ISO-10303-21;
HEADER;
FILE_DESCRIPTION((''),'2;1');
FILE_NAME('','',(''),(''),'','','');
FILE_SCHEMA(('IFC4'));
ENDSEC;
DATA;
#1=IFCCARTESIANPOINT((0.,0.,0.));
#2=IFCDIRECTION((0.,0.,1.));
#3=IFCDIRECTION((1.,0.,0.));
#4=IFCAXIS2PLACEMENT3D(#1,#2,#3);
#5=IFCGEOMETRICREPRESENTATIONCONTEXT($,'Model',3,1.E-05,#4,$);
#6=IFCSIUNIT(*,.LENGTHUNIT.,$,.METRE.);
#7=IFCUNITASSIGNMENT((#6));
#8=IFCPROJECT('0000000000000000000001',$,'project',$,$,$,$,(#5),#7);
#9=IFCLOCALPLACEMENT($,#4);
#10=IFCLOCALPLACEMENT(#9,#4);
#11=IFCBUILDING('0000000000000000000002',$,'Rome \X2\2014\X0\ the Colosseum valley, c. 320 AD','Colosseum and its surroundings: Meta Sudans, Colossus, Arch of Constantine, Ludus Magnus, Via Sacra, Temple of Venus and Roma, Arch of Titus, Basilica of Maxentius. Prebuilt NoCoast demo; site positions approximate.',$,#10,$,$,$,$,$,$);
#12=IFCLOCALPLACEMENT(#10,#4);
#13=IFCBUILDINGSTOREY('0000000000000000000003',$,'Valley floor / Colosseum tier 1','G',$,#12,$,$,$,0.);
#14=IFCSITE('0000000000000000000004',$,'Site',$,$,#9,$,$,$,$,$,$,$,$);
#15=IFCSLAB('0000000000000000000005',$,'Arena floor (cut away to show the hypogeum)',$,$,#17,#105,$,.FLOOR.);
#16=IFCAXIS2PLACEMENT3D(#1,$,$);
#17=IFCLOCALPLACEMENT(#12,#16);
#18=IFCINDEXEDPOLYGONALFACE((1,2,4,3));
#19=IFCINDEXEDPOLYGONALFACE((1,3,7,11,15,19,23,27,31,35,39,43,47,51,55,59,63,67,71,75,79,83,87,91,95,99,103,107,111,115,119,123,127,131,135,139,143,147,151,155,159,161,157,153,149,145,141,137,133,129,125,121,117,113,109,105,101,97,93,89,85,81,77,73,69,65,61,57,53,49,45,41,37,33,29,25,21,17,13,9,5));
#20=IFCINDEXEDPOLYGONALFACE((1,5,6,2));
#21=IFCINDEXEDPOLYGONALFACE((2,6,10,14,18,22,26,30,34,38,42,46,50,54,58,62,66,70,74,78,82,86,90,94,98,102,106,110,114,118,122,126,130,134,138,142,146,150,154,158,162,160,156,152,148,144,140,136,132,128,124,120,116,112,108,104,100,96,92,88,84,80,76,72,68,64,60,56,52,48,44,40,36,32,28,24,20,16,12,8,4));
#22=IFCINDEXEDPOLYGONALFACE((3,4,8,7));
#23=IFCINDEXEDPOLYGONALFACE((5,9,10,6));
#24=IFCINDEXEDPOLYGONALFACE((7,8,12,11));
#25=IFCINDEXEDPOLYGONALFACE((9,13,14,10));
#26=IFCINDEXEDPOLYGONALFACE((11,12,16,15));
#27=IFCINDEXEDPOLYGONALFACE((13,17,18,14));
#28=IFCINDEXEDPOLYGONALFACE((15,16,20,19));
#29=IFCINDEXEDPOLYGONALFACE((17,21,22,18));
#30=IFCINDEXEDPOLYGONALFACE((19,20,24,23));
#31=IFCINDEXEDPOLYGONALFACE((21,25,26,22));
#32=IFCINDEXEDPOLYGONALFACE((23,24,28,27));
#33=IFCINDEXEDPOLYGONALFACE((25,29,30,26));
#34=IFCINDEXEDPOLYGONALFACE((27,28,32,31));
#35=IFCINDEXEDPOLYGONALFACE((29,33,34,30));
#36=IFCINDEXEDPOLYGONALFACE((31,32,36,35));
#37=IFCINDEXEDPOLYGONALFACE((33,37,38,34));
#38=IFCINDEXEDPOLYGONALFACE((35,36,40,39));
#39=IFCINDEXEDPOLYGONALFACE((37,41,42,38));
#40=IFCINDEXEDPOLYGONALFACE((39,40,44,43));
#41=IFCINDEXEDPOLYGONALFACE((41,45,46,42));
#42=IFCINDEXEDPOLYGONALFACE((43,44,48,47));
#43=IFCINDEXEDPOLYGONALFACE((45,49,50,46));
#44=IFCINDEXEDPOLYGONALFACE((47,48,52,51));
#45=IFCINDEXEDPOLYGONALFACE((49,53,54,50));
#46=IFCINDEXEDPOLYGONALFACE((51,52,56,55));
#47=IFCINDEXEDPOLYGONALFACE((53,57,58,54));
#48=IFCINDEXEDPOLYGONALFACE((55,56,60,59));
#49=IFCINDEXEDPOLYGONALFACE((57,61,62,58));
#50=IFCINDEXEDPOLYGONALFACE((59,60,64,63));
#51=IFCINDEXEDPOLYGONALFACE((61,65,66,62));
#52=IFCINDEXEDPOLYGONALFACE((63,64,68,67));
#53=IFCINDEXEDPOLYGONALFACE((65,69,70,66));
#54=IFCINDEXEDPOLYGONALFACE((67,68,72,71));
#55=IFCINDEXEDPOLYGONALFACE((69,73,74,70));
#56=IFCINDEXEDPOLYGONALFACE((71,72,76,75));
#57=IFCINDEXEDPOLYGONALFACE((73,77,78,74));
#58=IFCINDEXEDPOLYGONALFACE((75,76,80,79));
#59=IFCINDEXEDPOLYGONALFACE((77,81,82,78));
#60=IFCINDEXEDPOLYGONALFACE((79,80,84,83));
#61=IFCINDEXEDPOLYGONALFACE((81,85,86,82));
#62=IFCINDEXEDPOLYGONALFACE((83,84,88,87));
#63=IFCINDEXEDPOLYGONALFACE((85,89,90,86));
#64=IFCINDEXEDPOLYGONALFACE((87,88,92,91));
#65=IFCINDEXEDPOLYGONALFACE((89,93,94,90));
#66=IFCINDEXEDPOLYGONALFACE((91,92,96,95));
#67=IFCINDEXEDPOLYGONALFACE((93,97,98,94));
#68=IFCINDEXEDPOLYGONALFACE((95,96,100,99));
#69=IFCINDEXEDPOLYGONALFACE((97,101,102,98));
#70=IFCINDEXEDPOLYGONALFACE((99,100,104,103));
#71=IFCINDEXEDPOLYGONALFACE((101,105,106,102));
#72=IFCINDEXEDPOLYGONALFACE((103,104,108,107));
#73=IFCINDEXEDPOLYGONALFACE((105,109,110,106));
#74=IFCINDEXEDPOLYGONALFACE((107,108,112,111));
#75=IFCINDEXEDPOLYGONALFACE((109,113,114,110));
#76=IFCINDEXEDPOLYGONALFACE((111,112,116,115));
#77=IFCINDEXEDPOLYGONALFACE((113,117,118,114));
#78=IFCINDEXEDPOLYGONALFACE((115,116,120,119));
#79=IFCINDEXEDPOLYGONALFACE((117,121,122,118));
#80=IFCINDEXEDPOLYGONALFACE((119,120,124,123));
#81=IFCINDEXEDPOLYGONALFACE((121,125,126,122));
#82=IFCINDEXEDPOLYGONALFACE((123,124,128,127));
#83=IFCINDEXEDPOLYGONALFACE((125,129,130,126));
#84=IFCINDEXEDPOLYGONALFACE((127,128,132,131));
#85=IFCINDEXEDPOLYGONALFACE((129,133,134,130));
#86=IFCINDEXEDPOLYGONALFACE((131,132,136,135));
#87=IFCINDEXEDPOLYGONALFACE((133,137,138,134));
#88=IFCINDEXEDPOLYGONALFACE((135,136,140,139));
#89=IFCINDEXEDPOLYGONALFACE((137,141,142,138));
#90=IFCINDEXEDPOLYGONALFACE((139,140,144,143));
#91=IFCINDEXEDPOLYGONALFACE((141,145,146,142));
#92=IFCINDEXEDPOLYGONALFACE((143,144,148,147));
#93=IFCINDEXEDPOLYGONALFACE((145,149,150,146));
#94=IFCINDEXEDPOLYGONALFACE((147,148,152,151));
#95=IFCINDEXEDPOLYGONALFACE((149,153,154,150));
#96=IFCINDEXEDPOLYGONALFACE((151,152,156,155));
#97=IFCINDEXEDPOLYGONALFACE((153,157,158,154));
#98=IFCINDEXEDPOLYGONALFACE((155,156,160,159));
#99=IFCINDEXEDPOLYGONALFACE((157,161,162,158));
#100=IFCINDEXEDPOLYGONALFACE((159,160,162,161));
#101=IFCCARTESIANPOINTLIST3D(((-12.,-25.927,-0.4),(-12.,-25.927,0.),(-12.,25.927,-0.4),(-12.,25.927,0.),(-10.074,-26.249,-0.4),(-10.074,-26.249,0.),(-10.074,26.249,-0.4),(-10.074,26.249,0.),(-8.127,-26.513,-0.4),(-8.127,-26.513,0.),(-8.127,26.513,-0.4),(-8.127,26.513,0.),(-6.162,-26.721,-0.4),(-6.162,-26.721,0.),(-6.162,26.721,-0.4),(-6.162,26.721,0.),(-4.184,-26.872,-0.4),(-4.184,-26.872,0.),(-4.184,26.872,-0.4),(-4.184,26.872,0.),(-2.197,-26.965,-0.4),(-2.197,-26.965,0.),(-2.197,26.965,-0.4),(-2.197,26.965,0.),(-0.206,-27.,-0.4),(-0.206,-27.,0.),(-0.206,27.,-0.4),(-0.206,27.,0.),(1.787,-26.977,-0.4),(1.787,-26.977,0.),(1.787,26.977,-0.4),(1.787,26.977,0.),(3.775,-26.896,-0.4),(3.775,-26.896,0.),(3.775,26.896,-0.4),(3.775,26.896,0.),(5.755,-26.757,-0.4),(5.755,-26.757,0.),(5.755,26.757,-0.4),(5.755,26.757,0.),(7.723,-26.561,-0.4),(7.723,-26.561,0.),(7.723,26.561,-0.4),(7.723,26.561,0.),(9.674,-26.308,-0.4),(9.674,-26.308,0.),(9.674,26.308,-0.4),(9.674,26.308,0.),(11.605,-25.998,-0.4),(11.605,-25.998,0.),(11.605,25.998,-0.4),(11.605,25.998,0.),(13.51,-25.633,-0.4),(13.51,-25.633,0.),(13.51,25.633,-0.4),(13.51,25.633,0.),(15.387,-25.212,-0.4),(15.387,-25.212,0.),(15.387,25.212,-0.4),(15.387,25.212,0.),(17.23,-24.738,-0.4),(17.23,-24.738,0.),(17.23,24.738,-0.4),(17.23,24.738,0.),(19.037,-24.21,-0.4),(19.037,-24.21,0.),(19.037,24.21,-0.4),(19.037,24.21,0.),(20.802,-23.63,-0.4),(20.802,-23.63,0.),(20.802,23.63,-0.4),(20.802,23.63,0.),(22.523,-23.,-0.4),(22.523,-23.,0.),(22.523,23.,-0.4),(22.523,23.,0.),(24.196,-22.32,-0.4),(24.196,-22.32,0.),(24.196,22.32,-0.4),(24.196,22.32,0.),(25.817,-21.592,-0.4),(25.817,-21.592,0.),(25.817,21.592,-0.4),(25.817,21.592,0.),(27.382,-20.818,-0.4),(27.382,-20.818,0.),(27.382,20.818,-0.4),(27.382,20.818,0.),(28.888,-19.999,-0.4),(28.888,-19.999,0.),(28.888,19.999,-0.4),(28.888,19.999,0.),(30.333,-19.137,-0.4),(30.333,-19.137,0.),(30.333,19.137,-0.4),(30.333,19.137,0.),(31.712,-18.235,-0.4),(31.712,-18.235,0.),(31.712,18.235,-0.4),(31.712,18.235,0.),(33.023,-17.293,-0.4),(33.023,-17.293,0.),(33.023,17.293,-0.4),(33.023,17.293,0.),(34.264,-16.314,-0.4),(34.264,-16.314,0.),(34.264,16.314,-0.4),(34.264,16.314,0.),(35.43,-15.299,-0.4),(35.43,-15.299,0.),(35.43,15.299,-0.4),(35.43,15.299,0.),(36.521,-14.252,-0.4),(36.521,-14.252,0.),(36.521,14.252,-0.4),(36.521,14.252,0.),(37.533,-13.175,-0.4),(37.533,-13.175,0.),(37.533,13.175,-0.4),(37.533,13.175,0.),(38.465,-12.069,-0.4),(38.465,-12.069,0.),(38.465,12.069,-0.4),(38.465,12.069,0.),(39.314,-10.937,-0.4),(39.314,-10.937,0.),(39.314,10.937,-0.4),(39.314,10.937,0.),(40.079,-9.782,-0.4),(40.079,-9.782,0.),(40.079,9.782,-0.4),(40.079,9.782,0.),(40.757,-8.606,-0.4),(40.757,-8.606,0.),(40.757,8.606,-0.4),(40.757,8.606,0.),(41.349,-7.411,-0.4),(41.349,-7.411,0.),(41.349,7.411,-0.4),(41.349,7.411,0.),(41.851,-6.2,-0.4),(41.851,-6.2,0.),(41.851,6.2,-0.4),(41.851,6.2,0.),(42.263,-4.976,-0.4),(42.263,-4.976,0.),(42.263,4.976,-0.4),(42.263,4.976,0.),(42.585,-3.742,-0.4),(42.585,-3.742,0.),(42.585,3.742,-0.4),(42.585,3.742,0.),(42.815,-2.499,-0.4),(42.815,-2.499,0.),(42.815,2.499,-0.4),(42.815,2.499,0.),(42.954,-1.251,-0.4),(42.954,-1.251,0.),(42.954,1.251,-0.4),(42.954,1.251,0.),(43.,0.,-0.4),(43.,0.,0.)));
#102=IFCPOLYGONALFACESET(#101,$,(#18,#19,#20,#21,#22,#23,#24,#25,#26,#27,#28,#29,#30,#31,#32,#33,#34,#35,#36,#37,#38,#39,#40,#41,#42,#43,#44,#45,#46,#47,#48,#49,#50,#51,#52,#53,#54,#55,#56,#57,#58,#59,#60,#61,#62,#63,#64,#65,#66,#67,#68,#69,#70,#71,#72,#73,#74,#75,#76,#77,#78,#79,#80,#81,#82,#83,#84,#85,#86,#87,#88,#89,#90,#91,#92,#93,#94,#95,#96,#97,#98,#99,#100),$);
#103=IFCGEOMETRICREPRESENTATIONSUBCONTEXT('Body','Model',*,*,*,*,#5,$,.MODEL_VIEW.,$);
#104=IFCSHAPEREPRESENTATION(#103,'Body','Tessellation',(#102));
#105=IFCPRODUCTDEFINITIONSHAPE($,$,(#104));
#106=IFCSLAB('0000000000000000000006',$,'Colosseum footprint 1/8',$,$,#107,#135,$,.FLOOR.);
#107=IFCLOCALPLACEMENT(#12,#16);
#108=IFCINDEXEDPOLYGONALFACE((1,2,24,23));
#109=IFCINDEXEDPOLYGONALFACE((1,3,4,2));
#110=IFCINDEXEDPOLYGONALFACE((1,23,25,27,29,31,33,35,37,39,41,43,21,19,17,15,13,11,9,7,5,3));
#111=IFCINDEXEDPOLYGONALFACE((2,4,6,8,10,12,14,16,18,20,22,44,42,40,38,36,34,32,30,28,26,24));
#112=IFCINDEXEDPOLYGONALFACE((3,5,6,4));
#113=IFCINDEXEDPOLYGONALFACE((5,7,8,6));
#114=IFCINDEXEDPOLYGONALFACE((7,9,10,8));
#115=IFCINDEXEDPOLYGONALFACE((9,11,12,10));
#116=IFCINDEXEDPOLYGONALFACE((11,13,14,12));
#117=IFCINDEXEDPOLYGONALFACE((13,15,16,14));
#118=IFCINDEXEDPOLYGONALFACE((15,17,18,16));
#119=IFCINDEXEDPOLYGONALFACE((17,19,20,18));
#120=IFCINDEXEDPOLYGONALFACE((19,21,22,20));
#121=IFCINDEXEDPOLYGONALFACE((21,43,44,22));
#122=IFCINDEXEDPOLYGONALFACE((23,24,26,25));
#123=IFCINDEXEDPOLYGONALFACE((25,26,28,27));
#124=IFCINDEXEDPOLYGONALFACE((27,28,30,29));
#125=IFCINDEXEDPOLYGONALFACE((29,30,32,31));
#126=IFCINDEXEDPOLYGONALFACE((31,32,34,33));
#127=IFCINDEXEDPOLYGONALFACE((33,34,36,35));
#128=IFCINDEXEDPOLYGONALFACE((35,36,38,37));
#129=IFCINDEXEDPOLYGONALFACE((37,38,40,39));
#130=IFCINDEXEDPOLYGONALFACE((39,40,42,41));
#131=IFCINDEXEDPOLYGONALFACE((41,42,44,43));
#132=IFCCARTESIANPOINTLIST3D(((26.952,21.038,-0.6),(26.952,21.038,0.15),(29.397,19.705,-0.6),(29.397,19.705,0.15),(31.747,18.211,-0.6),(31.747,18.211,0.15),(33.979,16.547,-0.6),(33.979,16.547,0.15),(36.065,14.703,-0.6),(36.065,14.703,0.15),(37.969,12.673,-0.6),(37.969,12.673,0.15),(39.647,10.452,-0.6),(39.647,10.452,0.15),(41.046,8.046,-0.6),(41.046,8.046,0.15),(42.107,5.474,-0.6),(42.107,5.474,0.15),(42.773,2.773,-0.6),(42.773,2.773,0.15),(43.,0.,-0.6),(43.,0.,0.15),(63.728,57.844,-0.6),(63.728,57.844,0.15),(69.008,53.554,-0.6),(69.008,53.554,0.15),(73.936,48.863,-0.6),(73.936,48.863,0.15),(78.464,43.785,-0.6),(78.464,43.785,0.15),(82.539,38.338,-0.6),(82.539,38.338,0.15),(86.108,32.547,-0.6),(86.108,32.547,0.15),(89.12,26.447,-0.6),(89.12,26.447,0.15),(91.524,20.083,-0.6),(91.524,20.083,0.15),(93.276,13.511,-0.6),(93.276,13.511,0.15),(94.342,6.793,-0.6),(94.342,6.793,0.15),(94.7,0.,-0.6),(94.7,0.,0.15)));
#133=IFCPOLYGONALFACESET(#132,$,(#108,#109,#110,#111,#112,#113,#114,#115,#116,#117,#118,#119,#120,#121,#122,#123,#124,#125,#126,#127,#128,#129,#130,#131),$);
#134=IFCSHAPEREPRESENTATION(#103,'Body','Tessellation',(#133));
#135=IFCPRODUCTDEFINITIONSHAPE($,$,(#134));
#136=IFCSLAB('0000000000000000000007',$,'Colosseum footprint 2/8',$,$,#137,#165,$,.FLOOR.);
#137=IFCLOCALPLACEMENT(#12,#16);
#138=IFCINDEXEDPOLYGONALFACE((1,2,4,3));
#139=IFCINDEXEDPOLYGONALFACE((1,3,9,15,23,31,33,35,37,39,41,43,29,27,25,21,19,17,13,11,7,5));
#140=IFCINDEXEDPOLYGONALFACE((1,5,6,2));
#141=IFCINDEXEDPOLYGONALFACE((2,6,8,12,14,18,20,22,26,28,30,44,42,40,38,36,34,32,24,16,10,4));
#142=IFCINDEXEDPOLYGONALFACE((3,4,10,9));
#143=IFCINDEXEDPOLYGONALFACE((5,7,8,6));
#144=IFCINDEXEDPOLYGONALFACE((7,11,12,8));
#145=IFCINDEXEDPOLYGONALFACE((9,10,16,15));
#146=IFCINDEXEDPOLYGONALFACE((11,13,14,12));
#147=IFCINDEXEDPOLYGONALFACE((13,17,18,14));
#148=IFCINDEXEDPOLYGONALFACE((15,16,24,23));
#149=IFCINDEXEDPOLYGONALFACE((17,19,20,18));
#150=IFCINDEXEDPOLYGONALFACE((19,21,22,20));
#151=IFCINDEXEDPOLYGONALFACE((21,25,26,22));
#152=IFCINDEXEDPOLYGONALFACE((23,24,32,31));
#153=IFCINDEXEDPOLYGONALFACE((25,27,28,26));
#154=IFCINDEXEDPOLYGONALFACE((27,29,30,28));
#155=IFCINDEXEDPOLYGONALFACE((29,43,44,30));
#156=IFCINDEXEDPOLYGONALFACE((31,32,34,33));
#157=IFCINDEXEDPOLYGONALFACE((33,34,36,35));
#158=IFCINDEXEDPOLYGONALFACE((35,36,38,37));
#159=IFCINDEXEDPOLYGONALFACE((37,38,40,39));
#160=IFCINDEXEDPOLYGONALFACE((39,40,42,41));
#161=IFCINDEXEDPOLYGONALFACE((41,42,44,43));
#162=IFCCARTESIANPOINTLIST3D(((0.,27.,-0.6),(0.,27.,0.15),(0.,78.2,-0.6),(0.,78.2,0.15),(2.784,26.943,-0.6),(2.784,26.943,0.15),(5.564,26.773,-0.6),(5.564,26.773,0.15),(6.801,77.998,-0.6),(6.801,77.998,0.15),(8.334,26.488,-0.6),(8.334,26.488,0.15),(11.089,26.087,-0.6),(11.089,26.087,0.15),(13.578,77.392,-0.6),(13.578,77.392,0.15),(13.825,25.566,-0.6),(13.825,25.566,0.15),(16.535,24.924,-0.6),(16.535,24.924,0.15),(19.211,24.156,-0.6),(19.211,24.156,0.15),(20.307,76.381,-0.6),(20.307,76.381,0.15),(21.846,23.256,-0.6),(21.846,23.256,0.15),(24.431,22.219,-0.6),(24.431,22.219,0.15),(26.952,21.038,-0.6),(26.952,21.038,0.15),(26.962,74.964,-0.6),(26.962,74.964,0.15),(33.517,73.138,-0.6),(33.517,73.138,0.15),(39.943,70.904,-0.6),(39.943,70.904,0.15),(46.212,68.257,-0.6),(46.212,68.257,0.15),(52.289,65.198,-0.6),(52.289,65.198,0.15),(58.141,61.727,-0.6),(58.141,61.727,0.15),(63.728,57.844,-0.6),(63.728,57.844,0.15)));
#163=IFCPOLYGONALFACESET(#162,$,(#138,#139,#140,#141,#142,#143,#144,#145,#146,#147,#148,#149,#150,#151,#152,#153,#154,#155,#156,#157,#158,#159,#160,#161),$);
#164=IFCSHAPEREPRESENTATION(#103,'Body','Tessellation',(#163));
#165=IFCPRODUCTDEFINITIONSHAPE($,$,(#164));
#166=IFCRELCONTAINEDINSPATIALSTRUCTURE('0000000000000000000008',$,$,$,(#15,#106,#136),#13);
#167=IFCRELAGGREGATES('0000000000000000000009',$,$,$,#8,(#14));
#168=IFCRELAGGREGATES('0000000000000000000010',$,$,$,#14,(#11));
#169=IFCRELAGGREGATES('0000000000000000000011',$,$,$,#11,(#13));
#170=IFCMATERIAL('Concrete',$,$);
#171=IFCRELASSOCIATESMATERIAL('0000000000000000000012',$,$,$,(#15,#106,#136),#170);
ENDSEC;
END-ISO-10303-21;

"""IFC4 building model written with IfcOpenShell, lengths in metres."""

from ifc_helpers import new_model, si_unit, frame, origin_with_axes, place, context, subcontext, project, spatial, indexed_curve, outline, extrude, material, element, save


model = new_model("IFC4")

# Units and contexts
model_context = context("Model", 3, precision=1e-05, world=origin_with_axes())
body_context = subcontext(model_context, "Body", "Model", "MODEL_VIEW")
ifc_project = project(units=[si_unit("LENGTHUNIT", "METRE")], contexts=[model_context])

# Site, building, storey
site_placement = place(None, origin_with_axes())
site = spatial("IfcSite", under=ifc_project, at=site_placement, Name="Site")
building_placement = place(site_placement, origin_with_axes())
building = spatial("IfcBuilding", under=site, at=building_placement, Name="Rome — the Colosseum valley, c. 320 AD", Description="Colosseum and its surroundings: Meta Sudans, Colossus, Arch of Constantine, Ludus Magnus, Via Sacra, Temple of Venus and Roma, Arch of Titus, Basilica of Maxentius. Prebuilt NoCoast demo; site positions approximate.")
storey_placement = place(building_placement, origin_with_axes())
storey = spatial("IfcBuildingStorey", under=building, at=storey_placement, Name="Valley floor / Colosseum tier 1", Description="G", Elevation=0.0)

# Slabs
ifc_material_1 = material(Name="Concrete")
slab_1_placement = place(storey_placement, frame((0.0, 0.0, -0.4), z_axis=(0.0, 0.0, 1.0), x_axis=(1.0, 0.0, 0.0)))
element("IfcSlab", 1, at=slab_1_placement, inside=storey, material=ifc_material_1, Name="Arena floor (cut away to show the hypogeum)", PredefinedType="FLOOR", context=body_context, shape_type="SweptSolid", body=[
    extrude(outline(indexed_curve([(-12.0, -25.927), (-10.074, -26.249), (-8.127, -26.513), (-6.162, -26.721), (-4.184, -26.872), (-2.197, -26.965), (-0.206, -27.0), (1.787, -26.977), (3.775, -26.896), (5.755, -26.757), (7.723, -26.561), (9.674, -26.308), (11.605, -25.998), (13.51, -25.633), (15.387, -25.212), (17.23, -24.738), (19.037, -24.21), (20.802, -23.63), (22.523, -23.0), (24.196, -22.32), (25.817, -21.592), (27.382, -20.818), (28.888, -19.999), (30.333, -19.137), (31.712, -18.235), (33.023, -17.293), (34.264, -16.314), (35.43, -15.299), (36.521, -14.252), (37.533, -13.175), (38.465, -12.069), (39.314, -10.937), (40.079, -9.782), (40.757, -8.606), (41.349, -7.411), (41.851, -6.2), (42.263, -4.976), (42.585, -3.742), (42.815, -2.499), (42.954, -1.251), (43.0, 0.0), (42.954, 1.251), (42.815, 2.499), (42.585, 3.742), (42.263, 4.976), (41.851, 6.2), (41.349, 7.411), (40.757, 8.606), (40.079, 9.782), (39.314, 10.937), (38.465, 12.069), (37.533, 13.175), (36.521, 14.252), (35.43, 15.299), (34.264, 16.314), (33.023, 17.293), (31.712, 18.235), (30.333, 19.137), (28.888, 19.999), (27.382, 20.818), (25.817, 21.592), (24.196, 22.32), (22.523, 23.0), (20.802, 23.63), (19.037, 24.21), (17.23, 24.738), (15.387, 25.212), (13.51, 25.633), (11.605, 25.998), (9.674, 26.308), (7.723, 26.561), (5.755, 26.757), (3.775, 26.896), (1.787, 26.977), (-0.206, 27.0), (-2.197, 26.965), (-4.184, 26.872), (-6.162, 26.721), (-8.127, 26.513), (-10.074, 26.249), (-12.0, 25.927)])), None, (0.0, 0.0, 1.0), 0.4),
])
slab_2_placement = place(storey_placement, frame((0.0, 0.0, -0.6), z_axis=(0.0, 0.0, 1.0), x_axis=(1.0, 0.0, 0.0)))
element("IfcSlab", 2, at=slab_2_placement, inside=storey, material=ifc_material_1, Name="Colosseum footprint 1/8", PredefinedType="FLOOR", context=body_context, shape_type="SweptSolid", body=[
    extrude(outline(indexed_curve([(43.0, 0.0), (42.773, 2.773), (42.107, 5.474), (41.046, 8.046), (39.647, 10.452), (37.969, 12.673), (36.065, 14.703), (33.979, 16.547), (31.747, 18.211), (29.397, 19.705), (26.952, 21.038), (63.728, 57.844), (69.008, 53.554), (73.936, 48.863), (78.464, 43.785), (82.539, 38.338), (86.108, 32.547), (89.12, 26.447), (91.524, 20.083), (93.276, 13.511), (94.342, 6.793), (94.7, 0.0)])), None, (0.0, 0.0, 1.0), 0.75),
])
slab_3_placement = place(storey_placement, frame((0.0, 0.0, -0.6), z_axis=(0.0, 0.0, 1.0), x_axis=(1.0, 0.0, 0.0)))
element("IfcSlab", 3, at=slab_3_placement, inside=storey, material=ifc_material_1, Name="Colosseum footprint 2/8", PredefinedType="FLOOR", context=body_context, shape_type="SweptSolid", body=[
    extrude(outline(indexed_curve([(26.952, 21.038), (24.431, 22.219), (21.846, 23.256), (19.211, 24.156), (16.535, 24.924), (13.825, 25.566), (11.089, 26.087), (8.334, 26.488), (5.564, 26.773), (2.784, 26.943), (0.0, 27.0), (0.0, 78.2), (6.801, 77.998), (13.578, 77.392), (20.307, 76.381), (26.962, 74.964), (33.517, 73.138), (39.943, 70.904), (46.212, 68.257), (52.289, 65.198), (58.141, 61.727), (63.728, 57.844)])), None, (0.0, 0.0, 1.0), 0.75),
])

save(model, "model.ifc")
